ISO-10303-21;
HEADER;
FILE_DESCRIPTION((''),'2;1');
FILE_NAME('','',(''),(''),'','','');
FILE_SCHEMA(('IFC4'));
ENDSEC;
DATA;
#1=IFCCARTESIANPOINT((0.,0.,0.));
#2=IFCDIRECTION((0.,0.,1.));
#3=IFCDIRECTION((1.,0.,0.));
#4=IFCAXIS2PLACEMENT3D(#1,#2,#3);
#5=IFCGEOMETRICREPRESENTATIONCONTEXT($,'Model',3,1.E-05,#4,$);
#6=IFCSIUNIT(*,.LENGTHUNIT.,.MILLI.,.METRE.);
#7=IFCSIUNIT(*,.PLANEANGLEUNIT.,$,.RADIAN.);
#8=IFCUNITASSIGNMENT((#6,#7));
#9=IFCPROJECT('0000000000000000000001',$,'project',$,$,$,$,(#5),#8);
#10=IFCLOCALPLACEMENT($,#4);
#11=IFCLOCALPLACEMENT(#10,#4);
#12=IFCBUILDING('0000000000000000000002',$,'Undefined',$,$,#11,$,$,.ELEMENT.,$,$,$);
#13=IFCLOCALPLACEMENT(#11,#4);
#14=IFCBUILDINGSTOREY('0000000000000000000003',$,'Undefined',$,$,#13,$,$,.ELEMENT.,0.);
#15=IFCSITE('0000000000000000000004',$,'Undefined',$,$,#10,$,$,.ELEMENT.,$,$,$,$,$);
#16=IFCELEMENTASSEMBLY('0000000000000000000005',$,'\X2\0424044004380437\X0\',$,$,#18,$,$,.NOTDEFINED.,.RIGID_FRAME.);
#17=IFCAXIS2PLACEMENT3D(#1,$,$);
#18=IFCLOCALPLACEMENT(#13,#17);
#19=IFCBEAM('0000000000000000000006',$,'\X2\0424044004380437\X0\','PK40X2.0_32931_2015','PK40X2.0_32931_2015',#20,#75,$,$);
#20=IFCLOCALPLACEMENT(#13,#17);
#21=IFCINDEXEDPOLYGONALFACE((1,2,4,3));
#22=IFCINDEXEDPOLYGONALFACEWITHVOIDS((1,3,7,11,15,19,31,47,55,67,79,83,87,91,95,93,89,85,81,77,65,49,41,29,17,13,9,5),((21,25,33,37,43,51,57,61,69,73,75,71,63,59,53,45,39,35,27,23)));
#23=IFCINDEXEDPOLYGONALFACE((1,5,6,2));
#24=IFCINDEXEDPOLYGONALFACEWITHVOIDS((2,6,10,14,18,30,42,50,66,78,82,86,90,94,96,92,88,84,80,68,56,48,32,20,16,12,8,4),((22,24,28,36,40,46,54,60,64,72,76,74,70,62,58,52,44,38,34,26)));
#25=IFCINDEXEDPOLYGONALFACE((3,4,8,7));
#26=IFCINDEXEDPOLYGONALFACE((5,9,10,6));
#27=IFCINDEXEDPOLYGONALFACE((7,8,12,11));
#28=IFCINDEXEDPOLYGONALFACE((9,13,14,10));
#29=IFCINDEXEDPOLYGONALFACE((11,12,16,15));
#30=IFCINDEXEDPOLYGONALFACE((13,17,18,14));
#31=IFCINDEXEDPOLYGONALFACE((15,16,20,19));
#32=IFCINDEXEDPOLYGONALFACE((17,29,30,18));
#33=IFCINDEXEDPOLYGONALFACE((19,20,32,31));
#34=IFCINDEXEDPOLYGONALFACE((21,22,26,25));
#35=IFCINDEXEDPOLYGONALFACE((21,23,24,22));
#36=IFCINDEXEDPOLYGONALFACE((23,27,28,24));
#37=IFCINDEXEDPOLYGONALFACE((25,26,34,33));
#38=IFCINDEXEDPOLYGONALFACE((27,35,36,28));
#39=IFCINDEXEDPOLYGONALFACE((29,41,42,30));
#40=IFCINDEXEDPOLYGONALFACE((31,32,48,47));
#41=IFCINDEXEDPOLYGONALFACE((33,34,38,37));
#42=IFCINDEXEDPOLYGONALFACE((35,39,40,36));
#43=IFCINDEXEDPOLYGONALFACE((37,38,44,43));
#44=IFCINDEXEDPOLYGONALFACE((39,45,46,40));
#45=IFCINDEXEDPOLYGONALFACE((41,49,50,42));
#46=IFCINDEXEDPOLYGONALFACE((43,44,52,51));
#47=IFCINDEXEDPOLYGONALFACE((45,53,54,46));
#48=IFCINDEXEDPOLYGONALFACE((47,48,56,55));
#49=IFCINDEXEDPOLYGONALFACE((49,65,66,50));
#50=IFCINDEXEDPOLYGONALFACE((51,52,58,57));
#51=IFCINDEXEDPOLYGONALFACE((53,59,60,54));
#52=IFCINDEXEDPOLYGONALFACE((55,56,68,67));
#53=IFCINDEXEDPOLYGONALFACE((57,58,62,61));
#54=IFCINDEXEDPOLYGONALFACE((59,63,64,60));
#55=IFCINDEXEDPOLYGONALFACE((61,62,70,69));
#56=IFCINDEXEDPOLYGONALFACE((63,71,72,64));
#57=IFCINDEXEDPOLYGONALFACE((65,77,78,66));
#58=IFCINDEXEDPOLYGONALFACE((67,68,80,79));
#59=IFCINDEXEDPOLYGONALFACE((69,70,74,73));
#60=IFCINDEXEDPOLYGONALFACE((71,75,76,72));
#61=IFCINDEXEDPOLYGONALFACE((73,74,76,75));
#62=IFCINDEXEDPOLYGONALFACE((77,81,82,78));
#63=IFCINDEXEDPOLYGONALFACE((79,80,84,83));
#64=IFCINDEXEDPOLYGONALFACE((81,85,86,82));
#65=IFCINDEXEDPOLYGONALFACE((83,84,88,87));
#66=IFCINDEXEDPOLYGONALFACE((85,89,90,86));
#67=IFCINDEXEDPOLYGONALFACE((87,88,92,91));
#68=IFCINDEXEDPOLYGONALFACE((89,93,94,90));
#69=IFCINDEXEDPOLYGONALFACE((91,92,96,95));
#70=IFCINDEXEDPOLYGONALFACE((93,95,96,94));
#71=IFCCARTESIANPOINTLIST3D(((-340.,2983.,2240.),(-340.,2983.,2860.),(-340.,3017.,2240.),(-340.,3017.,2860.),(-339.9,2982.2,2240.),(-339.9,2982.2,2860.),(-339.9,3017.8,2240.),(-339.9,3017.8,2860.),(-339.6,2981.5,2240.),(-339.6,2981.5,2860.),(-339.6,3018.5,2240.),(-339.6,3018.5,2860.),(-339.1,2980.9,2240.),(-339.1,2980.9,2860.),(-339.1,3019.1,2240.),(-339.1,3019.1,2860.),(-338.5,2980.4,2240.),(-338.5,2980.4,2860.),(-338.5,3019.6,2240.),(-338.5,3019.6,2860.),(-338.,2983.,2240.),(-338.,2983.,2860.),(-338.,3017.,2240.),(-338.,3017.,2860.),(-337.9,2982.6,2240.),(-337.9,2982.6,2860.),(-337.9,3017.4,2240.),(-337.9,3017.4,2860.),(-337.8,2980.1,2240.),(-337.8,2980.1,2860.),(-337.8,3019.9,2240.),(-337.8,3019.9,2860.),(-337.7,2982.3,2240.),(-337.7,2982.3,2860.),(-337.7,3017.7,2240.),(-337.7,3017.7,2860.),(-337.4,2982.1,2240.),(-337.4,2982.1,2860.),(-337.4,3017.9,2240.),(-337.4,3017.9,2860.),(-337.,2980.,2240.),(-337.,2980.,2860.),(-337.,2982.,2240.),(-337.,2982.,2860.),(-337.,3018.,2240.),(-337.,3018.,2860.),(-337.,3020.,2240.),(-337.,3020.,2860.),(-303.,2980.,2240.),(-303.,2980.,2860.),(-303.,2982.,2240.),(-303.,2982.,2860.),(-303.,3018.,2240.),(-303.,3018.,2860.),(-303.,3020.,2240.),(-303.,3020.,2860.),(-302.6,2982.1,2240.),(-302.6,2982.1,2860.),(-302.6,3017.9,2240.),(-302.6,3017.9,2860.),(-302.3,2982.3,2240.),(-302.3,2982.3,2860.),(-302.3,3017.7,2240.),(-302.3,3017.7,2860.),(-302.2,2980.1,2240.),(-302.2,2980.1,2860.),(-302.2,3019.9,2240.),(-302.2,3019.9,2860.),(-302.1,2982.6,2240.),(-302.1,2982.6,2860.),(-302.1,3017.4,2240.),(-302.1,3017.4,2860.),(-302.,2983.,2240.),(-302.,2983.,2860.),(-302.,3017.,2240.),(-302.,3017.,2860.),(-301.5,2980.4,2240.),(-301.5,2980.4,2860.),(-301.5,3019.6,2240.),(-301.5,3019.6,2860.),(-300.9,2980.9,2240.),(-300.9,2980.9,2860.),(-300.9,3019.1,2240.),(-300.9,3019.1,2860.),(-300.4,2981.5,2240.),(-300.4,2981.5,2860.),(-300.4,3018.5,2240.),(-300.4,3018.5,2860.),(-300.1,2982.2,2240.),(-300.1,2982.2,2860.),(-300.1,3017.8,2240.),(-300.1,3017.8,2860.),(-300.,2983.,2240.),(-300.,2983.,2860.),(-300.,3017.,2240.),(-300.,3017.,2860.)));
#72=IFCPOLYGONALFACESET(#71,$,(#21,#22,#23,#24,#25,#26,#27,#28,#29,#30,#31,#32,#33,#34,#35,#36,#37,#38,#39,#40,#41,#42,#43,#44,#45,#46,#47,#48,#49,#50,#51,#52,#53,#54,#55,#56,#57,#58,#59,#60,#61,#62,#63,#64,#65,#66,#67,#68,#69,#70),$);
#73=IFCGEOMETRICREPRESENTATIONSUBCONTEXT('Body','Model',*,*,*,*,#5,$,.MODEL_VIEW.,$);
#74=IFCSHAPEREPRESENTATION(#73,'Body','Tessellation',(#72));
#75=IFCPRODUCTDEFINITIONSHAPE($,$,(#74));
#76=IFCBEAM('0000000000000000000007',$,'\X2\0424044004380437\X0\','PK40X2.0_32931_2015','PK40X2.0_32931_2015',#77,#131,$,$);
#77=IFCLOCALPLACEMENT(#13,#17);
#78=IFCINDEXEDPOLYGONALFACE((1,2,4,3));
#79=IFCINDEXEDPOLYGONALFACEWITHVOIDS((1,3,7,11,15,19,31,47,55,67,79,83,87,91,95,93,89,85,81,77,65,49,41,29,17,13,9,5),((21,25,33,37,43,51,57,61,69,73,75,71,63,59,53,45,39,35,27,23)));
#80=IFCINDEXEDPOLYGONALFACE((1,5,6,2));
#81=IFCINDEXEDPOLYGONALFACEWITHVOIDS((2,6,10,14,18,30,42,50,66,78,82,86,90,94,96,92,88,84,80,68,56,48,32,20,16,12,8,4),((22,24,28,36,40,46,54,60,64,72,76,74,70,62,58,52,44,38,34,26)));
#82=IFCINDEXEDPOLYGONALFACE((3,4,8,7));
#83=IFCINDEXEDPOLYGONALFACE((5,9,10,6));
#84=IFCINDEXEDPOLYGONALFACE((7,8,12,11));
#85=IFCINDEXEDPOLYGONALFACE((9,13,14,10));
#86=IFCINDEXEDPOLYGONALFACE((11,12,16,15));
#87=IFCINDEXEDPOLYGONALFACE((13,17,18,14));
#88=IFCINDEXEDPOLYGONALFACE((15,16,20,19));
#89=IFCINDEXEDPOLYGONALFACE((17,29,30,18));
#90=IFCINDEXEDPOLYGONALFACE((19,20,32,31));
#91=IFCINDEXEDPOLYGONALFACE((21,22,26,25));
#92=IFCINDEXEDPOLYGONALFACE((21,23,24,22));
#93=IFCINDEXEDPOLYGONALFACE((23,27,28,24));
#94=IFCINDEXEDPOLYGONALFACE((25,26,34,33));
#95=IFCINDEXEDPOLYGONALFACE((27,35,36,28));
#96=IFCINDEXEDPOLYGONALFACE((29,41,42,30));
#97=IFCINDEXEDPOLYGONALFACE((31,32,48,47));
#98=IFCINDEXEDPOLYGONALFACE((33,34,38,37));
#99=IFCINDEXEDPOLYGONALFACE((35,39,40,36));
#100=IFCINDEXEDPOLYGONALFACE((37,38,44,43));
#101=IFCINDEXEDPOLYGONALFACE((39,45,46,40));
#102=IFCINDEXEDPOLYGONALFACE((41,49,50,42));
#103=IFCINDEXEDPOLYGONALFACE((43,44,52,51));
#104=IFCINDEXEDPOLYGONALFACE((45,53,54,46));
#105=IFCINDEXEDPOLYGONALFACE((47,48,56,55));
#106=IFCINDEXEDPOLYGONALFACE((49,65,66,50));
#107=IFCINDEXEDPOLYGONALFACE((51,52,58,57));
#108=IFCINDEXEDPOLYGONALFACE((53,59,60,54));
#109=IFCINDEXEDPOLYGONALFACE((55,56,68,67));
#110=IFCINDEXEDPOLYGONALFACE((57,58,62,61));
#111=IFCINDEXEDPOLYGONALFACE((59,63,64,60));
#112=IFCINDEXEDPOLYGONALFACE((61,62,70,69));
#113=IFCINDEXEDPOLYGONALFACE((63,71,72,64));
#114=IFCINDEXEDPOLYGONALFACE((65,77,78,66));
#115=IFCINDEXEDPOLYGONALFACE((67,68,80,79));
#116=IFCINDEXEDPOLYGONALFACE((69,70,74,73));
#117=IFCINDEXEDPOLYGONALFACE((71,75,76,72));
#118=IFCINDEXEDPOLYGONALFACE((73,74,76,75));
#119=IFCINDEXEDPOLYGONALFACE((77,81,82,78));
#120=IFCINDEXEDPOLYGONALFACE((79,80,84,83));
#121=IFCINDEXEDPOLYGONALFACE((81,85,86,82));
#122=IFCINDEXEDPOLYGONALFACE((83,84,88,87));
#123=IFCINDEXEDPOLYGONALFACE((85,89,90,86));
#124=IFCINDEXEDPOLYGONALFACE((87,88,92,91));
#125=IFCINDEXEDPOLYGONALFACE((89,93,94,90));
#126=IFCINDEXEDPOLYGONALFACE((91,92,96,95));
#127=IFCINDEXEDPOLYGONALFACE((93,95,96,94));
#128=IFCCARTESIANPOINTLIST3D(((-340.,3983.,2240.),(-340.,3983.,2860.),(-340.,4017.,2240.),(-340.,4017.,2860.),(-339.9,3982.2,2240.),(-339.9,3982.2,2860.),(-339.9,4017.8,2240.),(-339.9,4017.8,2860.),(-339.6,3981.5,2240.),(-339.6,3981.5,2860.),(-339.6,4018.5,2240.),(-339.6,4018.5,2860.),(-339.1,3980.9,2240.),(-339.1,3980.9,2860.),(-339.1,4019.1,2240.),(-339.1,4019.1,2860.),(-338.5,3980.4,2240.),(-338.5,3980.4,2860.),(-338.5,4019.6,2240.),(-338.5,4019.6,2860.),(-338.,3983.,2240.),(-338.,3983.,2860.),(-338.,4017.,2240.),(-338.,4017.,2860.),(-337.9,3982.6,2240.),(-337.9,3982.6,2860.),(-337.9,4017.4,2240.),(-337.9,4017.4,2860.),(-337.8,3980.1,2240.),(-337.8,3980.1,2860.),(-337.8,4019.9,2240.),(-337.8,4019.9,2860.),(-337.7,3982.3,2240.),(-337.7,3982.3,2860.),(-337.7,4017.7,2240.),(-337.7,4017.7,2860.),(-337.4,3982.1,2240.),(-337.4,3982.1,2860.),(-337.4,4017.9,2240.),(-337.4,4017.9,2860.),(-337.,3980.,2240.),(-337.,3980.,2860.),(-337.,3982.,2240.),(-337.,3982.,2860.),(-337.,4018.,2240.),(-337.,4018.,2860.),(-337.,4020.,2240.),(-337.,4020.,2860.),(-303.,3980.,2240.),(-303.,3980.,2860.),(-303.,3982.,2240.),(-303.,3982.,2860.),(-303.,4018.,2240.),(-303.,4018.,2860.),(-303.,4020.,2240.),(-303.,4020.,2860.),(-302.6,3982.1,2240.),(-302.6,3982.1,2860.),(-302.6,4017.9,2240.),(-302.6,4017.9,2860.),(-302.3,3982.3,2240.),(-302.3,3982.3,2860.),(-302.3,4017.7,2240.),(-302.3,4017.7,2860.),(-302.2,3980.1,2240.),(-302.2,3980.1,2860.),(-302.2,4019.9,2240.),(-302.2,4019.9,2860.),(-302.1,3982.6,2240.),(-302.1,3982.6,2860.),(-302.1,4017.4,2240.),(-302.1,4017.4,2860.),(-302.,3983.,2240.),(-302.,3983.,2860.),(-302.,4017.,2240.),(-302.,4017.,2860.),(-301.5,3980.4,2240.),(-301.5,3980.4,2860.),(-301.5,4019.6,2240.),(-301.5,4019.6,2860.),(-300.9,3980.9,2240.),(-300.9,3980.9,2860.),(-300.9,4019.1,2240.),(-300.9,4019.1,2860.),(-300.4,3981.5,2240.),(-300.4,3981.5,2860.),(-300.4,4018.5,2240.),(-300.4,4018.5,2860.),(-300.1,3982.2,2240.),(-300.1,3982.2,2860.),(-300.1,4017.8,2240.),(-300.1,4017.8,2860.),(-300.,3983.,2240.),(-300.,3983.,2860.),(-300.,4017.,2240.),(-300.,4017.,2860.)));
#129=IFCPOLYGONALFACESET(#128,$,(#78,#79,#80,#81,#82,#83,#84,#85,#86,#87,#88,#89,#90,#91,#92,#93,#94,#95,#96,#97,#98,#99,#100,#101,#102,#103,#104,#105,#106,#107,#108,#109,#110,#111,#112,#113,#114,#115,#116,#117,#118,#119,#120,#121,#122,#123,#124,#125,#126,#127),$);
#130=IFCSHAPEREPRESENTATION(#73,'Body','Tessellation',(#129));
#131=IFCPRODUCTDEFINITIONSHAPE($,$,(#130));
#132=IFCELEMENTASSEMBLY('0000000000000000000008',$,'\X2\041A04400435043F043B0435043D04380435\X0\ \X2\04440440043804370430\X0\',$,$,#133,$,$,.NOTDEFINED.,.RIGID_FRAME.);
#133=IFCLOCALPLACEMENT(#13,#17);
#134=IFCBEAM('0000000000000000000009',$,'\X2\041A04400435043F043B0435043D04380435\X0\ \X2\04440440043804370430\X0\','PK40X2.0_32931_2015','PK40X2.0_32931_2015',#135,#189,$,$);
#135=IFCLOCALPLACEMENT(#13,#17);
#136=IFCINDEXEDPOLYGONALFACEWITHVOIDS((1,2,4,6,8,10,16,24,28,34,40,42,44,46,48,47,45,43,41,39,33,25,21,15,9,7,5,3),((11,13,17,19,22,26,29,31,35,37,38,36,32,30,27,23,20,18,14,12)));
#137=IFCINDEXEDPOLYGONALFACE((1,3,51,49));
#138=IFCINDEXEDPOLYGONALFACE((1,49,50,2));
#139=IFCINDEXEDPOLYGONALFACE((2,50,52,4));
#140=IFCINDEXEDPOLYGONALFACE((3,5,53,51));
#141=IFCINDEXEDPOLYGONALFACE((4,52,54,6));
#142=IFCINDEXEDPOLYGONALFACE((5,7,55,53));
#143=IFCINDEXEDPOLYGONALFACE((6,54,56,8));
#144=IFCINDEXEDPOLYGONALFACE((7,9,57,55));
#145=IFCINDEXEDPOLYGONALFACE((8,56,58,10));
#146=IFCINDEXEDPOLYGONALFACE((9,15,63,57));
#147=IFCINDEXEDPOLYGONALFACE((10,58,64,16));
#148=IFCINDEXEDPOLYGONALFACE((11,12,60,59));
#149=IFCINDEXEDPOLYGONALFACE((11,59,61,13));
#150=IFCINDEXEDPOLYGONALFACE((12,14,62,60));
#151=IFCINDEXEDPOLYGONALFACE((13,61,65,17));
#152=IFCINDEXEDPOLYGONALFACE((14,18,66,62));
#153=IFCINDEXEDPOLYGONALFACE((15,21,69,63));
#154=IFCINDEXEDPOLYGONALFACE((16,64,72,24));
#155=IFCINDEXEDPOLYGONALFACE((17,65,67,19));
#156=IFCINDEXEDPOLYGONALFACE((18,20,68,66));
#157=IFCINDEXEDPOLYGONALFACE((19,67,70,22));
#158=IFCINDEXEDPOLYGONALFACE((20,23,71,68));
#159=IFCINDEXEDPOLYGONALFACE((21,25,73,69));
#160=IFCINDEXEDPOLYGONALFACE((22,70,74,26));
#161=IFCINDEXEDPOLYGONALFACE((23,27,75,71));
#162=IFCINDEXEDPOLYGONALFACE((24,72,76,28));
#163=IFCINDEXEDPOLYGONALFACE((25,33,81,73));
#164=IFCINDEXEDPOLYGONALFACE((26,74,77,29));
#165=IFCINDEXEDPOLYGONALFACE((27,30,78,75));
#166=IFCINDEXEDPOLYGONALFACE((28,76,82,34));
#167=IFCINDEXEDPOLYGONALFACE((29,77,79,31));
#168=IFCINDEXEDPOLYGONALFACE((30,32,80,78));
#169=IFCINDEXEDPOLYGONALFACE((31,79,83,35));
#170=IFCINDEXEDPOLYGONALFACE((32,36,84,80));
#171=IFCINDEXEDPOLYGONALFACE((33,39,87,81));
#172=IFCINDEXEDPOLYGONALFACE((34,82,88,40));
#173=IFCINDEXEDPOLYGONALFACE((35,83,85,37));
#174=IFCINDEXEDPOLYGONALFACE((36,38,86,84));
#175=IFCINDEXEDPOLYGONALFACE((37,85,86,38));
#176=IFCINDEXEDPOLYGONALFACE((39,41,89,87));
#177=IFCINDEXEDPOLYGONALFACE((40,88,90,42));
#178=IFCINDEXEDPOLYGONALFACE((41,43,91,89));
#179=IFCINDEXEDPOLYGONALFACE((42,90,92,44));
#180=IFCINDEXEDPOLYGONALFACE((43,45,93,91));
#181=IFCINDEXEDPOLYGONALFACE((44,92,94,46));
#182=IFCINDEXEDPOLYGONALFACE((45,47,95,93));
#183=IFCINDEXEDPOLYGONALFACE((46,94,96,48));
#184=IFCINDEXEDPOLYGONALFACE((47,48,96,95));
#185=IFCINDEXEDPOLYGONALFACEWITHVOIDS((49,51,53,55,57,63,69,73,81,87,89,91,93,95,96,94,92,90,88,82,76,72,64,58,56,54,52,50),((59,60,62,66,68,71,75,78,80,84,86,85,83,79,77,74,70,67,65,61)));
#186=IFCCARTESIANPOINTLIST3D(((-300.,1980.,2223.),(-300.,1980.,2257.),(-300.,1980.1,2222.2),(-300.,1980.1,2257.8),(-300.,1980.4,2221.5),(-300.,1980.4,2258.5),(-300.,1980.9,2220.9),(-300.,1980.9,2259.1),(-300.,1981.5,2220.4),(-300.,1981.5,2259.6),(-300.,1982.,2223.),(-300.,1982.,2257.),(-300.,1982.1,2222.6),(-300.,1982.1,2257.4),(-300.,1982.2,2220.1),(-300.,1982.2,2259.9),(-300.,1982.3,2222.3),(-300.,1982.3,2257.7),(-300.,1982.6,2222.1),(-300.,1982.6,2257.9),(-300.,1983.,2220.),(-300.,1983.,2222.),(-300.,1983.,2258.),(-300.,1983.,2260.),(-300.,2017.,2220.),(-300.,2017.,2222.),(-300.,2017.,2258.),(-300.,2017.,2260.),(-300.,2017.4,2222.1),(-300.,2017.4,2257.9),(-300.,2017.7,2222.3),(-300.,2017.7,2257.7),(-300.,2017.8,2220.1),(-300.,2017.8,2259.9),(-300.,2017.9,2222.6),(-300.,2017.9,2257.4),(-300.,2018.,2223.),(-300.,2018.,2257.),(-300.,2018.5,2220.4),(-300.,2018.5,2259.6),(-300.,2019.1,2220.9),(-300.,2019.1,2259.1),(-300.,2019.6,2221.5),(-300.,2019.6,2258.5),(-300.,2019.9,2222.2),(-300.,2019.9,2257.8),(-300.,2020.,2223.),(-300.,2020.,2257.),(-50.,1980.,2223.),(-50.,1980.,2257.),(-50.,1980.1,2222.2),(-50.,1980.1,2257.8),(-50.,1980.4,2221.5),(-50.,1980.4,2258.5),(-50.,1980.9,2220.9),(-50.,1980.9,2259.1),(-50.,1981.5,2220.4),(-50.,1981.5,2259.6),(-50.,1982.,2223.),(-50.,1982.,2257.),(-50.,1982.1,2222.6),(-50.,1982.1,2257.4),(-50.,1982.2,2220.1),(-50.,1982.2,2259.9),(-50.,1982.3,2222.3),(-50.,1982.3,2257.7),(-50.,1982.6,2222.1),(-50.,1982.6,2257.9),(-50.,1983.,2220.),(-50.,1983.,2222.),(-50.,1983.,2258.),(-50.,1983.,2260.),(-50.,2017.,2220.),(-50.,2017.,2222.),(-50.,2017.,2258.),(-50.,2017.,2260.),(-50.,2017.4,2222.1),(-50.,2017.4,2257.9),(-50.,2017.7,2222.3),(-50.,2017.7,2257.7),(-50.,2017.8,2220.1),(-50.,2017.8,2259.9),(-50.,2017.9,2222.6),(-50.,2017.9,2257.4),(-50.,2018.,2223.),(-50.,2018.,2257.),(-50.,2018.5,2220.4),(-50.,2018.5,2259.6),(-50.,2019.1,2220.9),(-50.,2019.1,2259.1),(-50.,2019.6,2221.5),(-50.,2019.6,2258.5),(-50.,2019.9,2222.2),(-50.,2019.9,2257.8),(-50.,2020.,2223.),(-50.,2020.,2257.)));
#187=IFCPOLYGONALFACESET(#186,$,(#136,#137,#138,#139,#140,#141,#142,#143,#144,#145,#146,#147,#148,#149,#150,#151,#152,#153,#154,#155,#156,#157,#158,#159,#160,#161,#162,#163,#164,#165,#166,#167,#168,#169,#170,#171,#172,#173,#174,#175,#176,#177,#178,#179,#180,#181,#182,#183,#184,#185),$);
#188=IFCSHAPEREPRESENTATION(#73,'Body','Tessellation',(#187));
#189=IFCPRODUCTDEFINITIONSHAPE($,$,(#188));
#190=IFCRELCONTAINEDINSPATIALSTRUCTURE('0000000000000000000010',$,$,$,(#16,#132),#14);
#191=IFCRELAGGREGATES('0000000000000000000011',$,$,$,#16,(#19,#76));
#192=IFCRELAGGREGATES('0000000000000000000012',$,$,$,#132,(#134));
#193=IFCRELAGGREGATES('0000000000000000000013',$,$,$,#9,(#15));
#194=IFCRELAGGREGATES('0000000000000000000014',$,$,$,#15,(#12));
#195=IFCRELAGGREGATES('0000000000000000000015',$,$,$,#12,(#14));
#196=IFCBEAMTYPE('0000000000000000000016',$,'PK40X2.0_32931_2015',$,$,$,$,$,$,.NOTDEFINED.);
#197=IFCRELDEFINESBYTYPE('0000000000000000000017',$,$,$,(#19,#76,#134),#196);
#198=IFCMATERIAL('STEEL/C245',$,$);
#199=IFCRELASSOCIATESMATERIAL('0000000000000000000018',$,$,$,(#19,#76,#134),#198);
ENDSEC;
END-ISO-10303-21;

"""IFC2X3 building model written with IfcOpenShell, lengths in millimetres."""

from ifc_helpers import new_model, si_unit, frame, origin_with_axes, origin_2d_with_axis, place, context, subcontext, project, spatial, hollow_rectangle, extrude, material, type_object, element, aggregate, save


model = new_model("IFC2X3")

# Units and contexts
model_context = context("Model", 3, precision=1e-05, world=origin_with_axes())
body_context = subcontext(model_context, "Body", "Model", "MODEL_VIEW")
ifc_project = project(units=[si_unit("LENGTHUNIT", "METRE", prefix="MILLI"), si_unit("PLANEANGLEUNIT", "RADIAN")], contexts=[model_context])

# Site, building, storey
site_placement = place(None, origin_with_axes())
site = spatial("IfcSite", under=ifc_project, at=site_placement, Name="Undefined", CompositionType="ELEMENT")
building_placement = place(site_placement, origin_with_axes())
building = spatial("IfcBuilding", under=site, at=building_placement, Name="Undefined", CompositionType="ELEMENT")
storey_placement = place(building_placement, origin_with_axes())
storey = spatial("IfcBuildingStorey", under=building, at=storey_placement, Name="Undefined", CompositionType="ELEMENT", Elevation=0.0)

# Shared definitions
ifc_material_1 = material(Name="STEEL/C245")

# Element assembly
assembly_1_placement = place(storey_placement, origin_with_axes())
assembly_1 = element("IfcElementAssembly", 1, at=assembly_1_placement, inside=storey, Name="Фриз", AssemblyPlace="NOTDEFINED", PredefinedType="RIGID_FRAME")

# Shared definitions
beam_type_1 = type_object("IfcBeamType", Name="PK40X2.0_32931_2015", PredefinedType="NOTDEFINED")

# Beams
beam_1_placement = place(assembly_1_placement, frame((-320.0, 3000.0, 2860.0), z_axis=(1.0, 0.0, 0.0), x_axis=(0.0, 0.0, -1.0)))
beam_1 = element("IfcBeam", 2, at=beam_1_placement, type_object=beam_type_1, material=ifc_material_1, Name="Фриз", Description="PK40X2.0_32931_2015", ObjectType="PK40X2.0_32931_2015", context=body_context, shape_type="SweptSolid", body=[
    extrude(hollow_rectangle(XDim=40.0, YDim=40.0, WallThickness=2.0, InnerFilletRadius=1.0, OuterFilletRadius=3.0, at=origin_2d_with_axis()), frame((620.0, 0.0, 0.0), z_axis=(-1.0, 0.0, 0.0), x_axis=(0.0, -1.0, 0.0)), (0.0, 0.0, 1.0), 620.0),
])
beam_2_placement = place(assembly_1_placement, frame((-320.0, 4000.0, 2860.0), z_axis=(1.0, 0.0, 0.0), x_axis=(0.0, 0.0, -1.0)))
beam_2 = element("IfcBeam", 3, at=beam_2_placement, type_object=beam_type_1, material=ifc_material_1, Name="Фриз", Description="PK40X2.0_32931_2015", ObjectType="PK40X2.0_32931_2015", context=body_context, shape_type="SweptSolid", body=[
    extrude(hollow_rectangle(XDim=40.0, YDim=40.0, WallThickness=2.0, InnerFilletRadius=1.0, OuterFilletRadius=3.0, at=origin_2d_with_axis()), frame((620.0, 0.0, 0.0), z_axis=(-1.0, 0.0, 0.0), x_axis=(0.0, -1.0, 0.0)), (0.0, 0.0, 1.0), 620.0),
])
aggregate(assembly_1, [beam_1, beam_2])

# Element assembly, beam
assembly_2_placement = place(storey_placement, origin_with_axes())
assembly_2 = element("IfcElementAssembly", 4, at=assembly_2_placement, inside=storey, Name="Крепление фриза", AssemblyPlace="NOTDEFINED", PredefinedType="RIGID_FRAME")
beam_3_placement = place(assembly_2_placement, frame((-300.0, 2000.0, 2240.0), z_axis=(0.0, 0.0, -1.0), x_axis=(1.0, 0.0, 0.0)))
beam_3 = element("IfcBeam", 5, at=beam_3_placement, type_object=beam_type_1, material=ifc_material_1, Name="Крепление фриза", Description="PK40X2.0_32931_2015", ObjectType="PK40X2.0_32931_2015", context=body_context, shape_type="SweptSolid", body=[
    extrude(hollow_rectangle(XDim=40.0, YDim=40.0, WallThickness=2.0, InnerFilletRadius=1.0, OuterFilletRadius=3.0, at=origin_2d_with_axis()), frame((250.0, 0.0, 0.0), z_axis=(-1.0, 0.0, 0.0), x_axis=(0.0, -1.0, 0.0)), (0.0, 0.0, 1.0), 250.0),
])
aggregate(assembly_2, [beam_3])

save(model, "model.ifc")
